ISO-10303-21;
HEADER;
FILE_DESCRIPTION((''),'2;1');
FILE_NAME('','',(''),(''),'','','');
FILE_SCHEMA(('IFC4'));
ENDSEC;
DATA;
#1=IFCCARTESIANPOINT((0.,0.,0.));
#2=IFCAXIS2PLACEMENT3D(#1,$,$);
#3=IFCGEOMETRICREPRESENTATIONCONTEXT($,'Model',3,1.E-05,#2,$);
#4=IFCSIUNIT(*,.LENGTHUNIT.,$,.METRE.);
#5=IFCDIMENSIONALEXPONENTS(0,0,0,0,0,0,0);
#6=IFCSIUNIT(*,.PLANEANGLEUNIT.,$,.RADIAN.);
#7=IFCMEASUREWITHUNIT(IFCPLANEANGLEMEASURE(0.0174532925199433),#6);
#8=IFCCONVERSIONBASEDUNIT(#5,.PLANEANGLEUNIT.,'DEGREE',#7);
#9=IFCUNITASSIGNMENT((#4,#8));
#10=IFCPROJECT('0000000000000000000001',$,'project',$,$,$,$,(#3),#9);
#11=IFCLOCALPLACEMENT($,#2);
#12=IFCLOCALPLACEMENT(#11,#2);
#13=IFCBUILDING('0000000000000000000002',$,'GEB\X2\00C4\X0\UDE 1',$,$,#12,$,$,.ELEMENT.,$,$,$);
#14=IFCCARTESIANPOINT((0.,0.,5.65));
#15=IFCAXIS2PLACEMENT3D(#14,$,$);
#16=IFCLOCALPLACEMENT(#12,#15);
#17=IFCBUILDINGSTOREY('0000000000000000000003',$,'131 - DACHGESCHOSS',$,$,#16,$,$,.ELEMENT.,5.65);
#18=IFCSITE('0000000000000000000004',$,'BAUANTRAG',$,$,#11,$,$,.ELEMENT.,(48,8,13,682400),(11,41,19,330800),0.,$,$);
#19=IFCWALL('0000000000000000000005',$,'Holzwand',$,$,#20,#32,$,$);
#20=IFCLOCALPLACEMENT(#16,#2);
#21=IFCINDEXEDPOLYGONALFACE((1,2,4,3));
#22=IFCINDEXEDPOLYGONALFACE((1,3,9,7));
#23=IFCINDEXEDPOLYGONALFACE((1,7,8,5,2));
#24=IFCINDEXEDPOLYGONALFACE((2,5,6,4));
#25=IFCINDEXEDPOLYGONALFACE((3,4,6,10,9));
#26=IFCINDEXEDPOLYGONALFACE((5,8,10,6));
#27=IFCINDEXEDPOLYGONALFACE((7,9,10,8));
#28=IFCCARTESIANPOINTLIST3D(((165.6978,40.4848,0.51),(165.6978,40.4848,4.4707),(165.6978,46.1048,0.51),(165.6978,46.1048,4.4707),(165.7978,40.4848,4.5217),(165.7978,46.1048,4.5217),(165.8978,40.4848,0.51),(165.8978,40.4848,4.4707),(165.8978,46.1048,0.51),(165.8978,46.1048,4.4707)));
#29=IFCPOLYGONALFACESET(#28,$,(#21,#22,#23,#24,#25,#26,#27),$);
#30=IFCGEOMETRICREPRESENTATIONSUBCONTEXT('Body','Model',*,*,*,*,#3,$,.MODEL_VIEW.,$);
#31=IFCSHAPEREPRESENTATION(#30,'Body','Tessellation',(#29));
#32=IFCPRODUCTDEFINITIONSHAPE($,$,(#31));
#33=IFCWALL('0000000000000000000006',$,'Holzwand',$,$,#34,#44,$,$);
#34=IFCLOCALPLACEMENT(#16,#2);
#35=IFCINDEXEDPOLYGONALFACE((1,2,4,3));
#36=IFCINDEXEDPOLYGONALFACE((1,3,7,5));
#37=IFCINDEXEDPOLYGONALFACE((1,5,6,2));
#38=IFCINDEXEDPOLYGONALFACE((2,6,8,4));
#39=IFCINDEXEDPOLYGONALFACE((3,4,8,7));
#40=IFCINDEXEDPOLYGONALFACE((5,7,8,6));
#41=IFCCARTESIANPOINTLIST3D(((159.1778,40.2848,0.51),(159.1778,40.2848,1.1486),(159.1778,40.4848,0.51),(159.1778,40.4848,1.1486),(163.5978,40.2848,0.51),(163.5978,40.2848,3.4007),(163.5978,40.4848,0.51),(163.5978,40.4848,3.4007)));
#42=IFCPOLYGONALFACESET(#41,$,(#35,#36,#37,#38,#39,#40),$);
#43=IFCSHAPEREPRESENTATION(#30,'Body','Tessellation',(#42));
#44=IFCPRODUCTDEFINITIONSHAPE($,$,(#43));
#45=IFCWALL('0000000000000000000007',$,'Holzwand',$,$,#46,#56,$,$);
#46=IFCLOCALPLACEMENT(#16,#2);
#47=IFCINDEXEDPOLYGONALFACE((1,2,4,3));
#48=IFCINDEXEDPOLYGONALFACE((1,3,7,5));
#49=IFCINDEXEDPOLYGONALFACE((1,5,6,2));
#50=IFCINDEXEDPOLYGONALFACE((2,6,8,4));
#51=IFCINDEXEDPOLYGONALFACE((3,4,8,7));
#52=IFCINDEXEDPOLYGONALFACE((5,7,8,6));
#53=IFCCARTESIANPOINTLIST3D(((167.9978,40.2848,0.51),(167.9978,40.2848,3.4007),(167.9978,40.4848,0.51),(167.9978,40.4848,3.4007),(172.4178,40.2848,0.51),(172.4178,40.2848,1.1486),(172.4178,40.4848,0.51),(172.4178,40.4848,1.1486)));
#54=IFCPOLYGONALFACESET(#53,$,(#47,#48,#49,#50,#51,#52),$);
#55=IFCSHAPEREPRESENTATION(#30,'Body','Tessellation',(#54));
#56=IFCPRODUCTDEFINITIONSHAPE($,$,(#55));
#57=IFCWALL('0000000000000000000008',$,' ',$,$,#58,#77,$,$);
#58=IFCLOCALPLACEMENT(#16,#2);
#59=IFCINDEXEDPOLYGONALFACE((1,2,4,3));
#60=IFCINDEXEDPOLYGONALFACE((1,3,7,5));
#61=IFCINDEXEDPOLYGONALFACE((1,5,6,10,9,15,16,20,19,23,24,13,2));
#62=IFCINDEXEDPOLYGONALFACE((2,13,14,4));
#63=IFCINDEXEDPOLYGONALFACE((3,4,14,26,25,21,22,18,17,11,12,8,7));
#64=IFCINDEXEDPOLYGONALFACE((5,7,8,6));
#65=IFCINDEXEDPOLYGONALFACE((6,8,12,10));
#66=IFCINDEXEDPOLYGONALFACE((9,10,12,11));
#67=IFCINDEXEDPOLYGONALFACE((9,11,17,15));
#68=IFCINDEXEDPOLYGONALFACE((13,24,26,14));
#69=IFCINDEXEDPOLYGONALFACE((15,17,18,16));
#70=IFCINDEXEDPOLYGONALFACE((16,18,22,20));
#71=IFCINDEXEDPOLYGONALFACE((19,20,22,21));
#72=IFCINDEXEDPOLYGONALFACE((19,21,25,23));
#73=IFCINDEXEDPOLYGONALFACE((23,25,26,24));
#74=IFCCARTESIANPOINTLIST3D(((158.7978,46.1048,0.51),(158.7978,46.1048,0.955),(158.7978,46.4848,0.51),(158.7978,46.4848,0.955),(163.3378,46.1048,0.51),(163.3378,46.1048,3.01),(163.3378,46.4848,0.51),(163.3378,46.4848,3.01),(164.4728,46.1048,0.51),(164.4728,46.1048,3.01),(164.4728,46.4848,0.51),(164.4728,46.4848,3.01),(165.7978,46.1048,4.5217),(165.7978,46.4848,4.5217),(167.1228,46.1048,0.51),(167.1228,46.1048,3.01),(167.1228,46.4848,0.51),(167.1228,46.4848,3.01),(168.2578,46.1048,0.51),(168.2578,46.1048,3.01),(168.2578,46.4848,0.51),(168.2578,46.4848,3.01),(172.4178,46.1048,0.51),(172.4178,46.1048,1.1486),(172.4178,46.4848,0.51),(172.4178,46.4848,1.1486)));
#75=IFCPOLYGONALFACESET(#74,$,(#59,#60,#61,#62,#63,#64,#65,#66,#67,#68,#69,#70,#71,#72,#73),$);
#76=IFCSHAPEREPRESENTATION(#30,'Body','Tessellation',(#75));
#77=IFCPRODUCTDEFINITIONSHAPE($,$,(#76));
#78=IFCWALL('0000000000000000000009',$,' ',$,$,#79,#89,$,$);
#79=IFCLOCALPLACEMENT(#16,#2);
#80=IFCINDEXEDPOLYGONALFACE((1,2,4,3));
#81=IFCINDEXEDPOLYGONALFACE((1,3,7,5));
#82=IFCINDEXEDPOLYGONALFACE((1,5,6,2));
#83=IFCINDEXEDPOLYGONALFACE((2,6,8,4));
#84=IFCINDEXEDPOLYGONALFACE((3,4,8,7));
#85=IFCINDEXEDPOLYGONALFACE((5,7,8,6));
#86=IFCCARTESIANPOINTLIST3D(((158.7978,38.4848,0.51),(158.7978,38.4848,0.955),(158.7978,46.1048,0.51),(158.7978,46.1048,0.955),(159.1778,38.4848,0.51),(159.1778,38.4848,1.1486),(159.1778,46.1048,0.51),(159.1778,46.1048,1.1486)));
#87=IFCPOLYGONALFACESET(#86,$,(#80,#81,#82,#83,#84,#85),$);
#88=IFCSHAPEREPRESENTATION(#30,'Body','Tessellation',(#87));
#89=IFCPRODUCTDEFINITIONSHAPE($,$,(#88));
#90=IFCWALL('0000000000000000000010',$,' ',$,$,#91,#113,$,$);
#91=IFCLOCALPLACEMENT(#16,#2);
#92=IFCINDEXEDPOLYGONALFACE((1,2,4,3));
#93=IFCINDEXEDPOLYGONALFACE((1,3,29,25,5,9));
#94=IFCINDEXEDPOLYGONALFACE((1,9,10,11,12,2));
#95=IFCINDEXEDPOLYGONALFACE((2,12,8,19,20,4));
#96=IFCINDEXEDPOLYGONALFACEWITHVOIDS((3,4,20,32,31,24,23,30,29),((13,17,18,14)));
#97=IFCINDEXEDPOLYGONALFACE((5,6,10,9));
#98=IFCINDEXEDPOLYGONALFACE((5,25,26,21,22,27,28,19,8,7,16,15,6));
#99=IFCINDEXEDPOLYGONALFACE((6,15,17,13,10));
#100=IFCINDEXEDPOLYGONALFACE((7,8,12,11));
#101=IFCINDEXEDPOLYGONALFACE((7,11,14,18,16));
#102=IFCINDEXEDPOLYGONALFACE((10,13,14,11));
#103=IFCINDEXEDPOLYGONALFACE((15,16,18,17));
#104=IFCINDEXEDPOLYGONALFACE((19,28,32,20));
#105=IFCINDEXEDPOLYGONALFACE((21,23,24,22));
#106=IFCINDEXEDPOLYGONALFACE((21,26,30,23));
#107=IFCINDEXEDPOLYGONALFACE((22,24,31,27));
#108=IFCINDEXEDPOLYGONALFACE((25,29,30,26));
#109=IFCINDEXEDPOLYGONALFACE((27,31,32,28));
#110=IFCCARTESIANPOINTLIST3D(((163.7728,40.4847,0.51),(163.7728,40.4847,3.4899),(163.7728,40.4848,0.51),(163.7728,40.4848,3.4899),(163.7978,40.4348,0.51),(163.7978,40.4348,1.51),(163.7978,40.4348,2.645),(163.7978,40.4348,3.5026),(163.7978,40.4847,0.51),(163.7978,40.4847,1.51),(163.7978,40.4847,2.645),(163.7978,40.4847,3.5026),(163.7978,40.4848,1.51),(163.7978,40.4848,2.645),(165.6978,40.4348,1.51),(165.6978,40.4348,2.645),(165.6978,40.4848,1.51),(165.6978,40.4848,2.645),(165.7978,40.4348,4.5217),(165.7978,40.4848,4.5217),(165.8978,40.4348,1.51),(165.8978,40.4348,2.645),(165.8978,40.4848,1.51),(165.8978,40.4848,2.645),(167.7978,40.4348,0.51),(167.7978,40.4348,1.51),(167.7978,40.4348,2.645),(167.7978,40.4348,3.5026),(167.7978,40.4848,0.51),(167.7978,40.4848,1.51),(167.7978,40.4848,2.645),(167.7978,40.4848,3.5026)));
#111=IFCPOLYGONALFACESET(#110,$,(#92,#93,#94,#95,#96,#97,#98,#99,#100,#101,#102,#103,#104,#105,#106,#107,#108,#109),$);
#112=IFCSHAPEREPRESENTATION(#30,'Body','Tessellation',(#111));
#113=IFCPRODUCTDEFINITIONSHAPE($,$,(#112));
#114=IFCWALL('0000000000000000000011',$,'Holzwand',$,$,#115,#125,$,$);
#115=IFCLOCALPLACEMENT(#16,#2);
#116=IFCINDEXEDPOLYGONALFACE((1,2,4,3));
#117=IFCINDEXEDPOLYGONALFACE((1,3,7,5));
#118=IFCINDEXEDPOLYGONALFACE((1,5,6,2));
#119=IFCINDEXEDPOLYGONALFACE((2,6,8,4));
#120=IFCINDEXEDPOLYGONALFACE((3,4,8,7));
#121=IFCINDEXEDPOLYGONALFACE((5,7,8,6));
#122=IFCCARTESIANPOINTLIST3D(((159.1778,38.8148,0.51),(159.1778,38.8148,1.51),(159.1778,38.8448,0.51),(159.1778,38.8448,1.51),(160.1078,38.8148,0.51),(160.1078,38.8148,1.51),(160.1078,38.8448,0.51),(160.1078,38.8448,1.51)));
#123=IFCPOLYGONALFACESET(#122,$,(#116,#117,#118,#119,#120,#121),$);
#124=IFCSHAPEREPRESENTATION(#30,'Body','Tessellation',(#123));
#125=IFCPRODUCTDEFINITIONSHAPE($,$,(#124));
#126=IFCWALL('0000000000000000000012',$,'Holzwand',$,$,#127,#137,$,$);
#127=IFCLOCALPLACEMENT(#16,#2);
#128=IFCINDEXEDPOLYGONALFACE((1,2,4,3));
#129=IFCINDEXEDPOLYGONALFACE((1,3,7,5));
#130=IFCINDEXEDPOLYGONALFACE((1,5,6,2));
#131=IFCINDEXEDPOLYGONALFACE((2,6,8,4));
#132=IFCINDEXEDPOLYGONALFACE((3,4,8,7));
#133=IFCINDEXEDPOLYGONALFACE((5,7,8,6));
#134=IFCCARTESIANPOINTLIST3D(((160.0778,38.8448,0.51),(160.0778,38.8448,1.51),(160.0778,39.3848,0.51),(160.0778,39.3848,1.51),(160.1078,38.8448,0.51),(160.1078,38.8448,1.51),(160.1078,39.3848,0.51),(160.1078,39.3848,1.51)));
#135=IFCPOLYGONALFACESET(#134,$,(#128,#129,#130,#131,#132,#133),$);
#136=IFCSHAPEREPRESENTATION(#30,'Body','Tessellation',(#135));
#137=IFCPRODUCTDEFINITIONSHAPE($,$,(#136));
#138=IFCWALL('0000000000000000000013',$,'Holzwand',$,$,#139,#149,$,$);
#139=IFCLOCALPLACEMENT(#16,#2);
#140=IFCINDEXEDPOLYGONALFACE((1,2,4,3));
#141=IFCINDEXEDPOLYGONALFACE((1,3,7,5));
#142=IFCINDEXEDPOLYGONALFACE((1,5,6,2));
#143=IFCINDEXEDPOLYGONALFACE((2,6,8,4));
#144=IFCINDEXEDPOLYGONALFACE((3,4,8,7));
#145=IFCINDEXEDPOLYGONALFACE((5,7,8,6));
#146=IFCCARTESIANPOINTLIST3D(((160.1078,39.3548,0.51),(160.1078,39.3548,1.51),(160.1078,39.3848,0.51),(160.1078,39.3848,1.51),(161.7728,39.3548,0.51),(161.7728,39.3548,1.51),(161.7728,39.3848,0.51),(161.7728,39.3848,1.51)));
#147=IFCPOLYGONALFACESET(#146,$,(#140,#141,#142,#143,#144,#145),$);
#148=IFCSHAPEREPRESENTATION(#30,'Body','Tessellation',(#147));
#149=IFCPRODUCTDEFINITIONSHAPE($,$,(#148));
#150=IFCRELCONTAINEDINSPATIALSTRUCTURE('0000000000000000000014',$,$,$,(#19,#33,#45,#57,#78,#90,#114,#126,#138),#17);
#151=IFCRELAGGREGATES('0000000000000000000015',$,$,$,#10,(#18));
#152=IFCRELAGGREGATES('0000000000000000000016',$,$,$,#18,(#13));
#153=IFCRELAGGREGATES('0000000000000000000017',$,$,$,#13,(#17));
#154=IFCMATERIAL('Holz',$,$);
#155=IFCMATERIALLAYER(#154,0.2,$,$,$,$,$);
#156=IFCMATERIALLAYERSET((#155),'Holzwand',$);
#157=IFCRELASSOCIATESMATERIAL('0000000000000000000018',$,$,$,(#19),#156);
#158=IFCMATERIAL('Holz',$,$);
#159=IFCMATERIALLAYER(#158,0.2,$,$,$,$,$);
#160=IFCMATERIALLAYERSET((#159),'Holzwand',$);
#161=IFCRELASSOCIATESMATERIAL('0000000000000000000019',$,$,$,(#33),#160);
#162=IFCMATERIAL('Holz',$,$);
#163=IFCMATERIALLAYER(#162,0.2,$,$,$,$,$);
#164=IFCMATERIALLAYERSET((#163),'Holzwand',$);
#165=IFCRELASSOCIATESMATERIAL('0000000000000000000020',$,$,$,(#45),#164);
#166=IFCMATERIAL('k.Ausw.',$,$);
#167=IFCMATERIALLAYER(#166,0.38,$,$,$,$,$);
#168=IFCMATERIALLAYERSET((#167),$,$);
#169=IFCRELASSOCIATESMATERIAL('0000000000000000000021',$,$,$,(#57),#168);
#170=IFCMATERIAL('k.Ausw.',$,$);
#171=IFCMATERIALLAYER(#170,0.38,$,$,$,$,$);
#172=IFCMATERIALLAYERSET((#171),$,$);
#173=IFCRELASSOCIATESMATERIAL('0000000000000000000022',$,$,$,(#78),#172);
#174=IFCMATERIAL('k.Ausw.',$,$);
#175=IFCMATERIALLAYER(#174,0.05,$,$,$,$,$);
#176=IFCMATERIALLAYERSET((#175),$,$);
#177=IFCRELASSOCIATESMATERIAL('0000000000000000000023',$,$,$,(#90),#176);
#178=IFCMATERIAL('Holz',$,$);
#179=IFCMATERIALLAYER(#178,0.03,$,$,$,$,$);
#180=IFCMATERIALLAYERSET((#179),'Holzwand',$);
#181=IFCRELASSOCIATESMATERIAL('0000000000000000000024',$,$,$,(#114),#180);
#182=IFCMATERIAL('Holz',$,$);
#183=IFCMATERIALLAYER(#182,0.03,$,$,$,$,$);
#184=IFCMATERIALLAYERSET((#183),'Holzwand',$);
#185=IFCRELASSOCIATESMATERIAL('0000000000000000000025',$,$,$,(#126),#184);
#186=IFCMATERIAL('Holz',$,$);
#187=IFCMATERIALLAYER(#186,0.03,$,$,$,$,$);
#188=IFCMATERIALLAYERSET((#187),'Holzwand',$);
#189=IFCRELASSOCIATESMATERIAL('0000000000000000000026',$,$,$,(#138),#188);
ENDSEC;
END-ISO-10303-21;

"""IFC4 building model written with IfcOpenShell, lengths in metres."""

from ifc_helpers import new_model, entity, si_unit, converted_unit, frame, frame_2d, origin, origin_with_axes, place, context, subcontext, project, spatial, polyline, rectangle, outline, extrude, clip, halfspace, bounded_halfspace, material, layer, layer_set, layer_usage, element, save


model = new_model("IFC4")

# Units and contexts
model_context = context("Model", 3, precision=1e-05, world=origin())
body_context = subcontext(model_context, "Body", "Model", "MODEL_VIEW")
ifc_project = project(units=[si_unit("LENGTHUNIT", "METRE"), converted_unit("PLANEANGLEUNIT", "DEGREE", entity("IfcPlaneAngleMeasure", 0.0174532925199433), si_unit("PLANEANGLEUNIT", "RADIAN"), dimensions=[0, 0, 0, 0, 0, 0, 0])], contexts=[model_context])

# Site, building, storey
site_placement = place(None, origin())
site = spatial("IfcSite", under=ifc_project, at=site_placement, Name="BAUANTRAG", CompositionType="ELEMENT", RefLatitude=(48, 8, 13, 682400), RefLongitude=(11, 41, 19, 330800), RefElevation=0.0)
building_placement = place(site_placement, origin())
building = spatial("IfcBuilding", under=site, at=building_placement, Name="GEBÄUDE 1", CompositionType="ELEMENT")
storey_placement = place(building_placement, frame((0.0, 0.0, 5.65)))
storey = spatial("IfcBuildingStorey", under=building, at=storey_placement, Name="131 - DACHGESCHOSS", CompositionType="ELEMENT", Elevation=5.65)

# Walls
ifc_material_1 = material(Name="Holz")
ifc_layer_1 = layer(ifc_material_1, 0.2)
ifc_layer_set_1 = layer_set([ifc_layer_1], Name="Holzwand")
ifc_layer_usage_1 = layer_usage(ifc_layer_set_1, "AXIS2", "POSITIVE", 0.0)
wall_1_placement = place(storey_placement, frame((165.6978, 46.1048, 0.51), z_axis=(0.0, 0.0, 1.0), x_axis=(0.0, -1.0, 0.0)))
element("IfcWall", 1, at=wall_1_placement, inside=storey, material=ifc_layer_usage_1, Name="Holzwand", context=body_context, shape_type="Clipping", body=[
    clip(clip(extrude(rectangle(XDim=5.62, YDim=0.2, at=frame_2d((2.81, 0.1), x_axis=(1.0, 0.0))), origin_with_axes(), (0.0, 0.0, 1.0), 4.0117), bounded_halfspace(frame((2.81, 0.05, 3.9862), z_axis=(0.0, 0.45399, -0.891007), x_axis=(0.0, 0.891007, 0.45399)), True, origin_with_axes(), polyline([(5.62, 0.0), (5.62, 0.1), (0.0, 0.1), (0.0, 0.0), (5.62, 0.0)]))), bounded_halfspace(frame((2.81, 0.15, 3.9862), z_axis=(0.0, -0.45399, -0.891007), x_axis=(0.0, -0.891007, 0.45399)), True, origin_with_axes(), polyline([(0.0, 0.2), (0.0, 0.1), (5.62, 0.1), (5.62, 0.2), (0.0, 0.2)]))),
])
ifc_material_2 = material(Name="Holz")
ifc_layer_2 = layer(ifc_material_2, 0.2)
ifc_layer_set_2 = layer_set([ifc_layer_2], Name="Holzwand")
ifc_layer_usage_2 = layer_usage(ifc_layer_set_2, "AXIS2", "POSITIVE", 0.0)
wall_2_placement = place(storey_placement, frame((163.5978, 40.4848, 0.51), z_axis=(0.0, 0.0, 1.0), x_axis=(-1.0, 0.0, 0.0)))
element("IfcWall", 2, at=wall_2_placement, inside=storey, material=ifc_layer_usage_2, Name="Holzwand", context=body_context, shape_type="Clipping", body=[
    clip(extrude(rectangle(XDim=4.42, YDim=0.2, at=frame_2d((2.21, 0.1), x_axis=(1.0, 0.0))), origin_with_axes(), (0.0, 0.0, 1.0), 2.8907), halfspace(frame((2.21, 0.1, 1.7647), z_axis=(-0.45399, 0.0, -0.891007), x_axis=(0.891007, 0.0, -0.45399)), True)),
])
ifc_material_3 = material(Name="Holz")
ifc_layer_3 = layer(ifc_material_3, 0.2)
ifc_layer_set_3 = layer_set([ifc_layer_3], Name="Holzwand")
ifc_layer_usage_3 = layer_usage(ifc_layer_set_3, "AXIS2", "POSITIVE", 0.0)
wall_3_placement = place(storey_placement, frame((172.4178, 40.4848, 0.51), z_axis=(0.0, 0.0, 1.0), x_axis=(-1.0, 0.0, 0.0)))
element("IfcWall", 3, at=wall_3_placement, inside=storey, material=ifc_layer_usage_3, Name="Holzwand", context=body_context, shape_type="Clipping", body=[
    clip(extrude(rectangle(XDim=4.42, YDim=0.2, at=frame_2d((2.21, 0.1), x_axis=(1.0, 0.0))), origin_with_axes(), (0.0, 0.0, 1.0), 2.8907), halfspace(frame((2.21, 0.1, 1.7647), z_axis=(0.45399, 0.0, -0.891007), x_axis=(0.891007, 0.0, 0.45399)), True)),
])

# Wall, openings
ifc_material_4 = material(Name="k.Ausw.")
ifc_layer_4 = layer(ifc_material_4, 0.38)
ifc_layer_set_4 = layer_set([ifc_layer_4])
ifc_layer_usage_4 = layer_usage(ifc_layer_set_4, "AXIS2", "POSITIVE", 0.0)
wall_4_placement = place(storey_placement, frame((172.4178, 46.4848, 0.51), z_axis=(0.0, 0.0, 1.0), x_axis=(-1.0, 0.0, 0.0)))
wall_4 = element("IfcWall", 4, at=wall_4_placement, inside=storey, material=ifc_layer_usage_4, Name=" ", context=body_context, shape_type="Clipping", body=[
    clip(clip(extrude(rectangle(XDim=13.62, YDim=0.38, at=frame_2d((6.81, 0.19), x_axis=(1.0, 0.0))), origin_with_axes(), (0.0, 0.0, 1.0), 4.0117), bounded_halfspace(frame((10.12, 0.19, 2.2283), z_axis=(-0.45399, 0.0, -0.891007), x_axis=(0.0, -1.0, 0.0)), True, origin_with_axes(), polyline([(6.62, 0.38), (6.62, 0.0), (13.62, 0.0), (13.62, 0.38), (6.62, 0.38)]))), bounded_halfspace(frame((3.31, 0.19, 2.3251), z_axis=(0.45399, 0.0, -0.891007), x_axis=(0.0, -1.0, 0.0)), True, origin_with_axes(), polyline([(0.0, 0.38), (0.0, 0.0), (6.62, 0.0), (6.62, 0.38), (0.0, 0.38)]))),
])
opening_1_placement = place(wall_4_placement, frame((5.295, 0.38, 0.0), z_axis=(0.0, -1.0, 0.0), x_axis=(0.0, 0.0, 1.0)))
element("IfcOpeningElement", 5, at=opening_1_placement, cuts=wall_4, ObjectType="Opening", context=body_context, shape_type="SweptSolid", body=[
    extrude(outline(polyline([(0.0, 1.135), (2.5, 1.135), (2.5, 0.0), (0.0, 0.0), (0.0, 1.135)])), origin_with_axes(), (0.0, 0.0, 1.0), 0.38),
])
opening_2_placement = place(wall_4_placement, frame((9.08, 0.38, 0.0), z_axis=(0.0, -1.0, 0.0), x_axis=(0.0, 0.0, 1.0)))
element("IfcOpeningElement", 6, at=opening_2_placement, cuts=wall_4, ObjectType="Opening", context=body_context, shape_type="SweptSolid", body=[
    extrude(outline(polyline([(0.0, 1.135), (2.5, 1.135), (2.5, 0.0), (0.0, 0.0), (0.0, 1.135)])), origin_with_axes(), (0.0, 0.0, 1.0), 0.38),
])

# Wall
ifc_material_5 = material(Name="k.Ausw.")
ifc_layer_5 = layer(ifc_material_5, 0.38)
ifc_layer_set_5 = layer_set([ifc_layer_5])
ifc_layer_usage_5 = layer_usage(ifc_layer_set_5, "AXIS2", "POSITIVE", 0.0)
wall_5_placement = place(storey_placement, frame((158.7978, 46.1048, 0.51), z_axis=(0.0, 0.0, 1.0), x_axis=(0.0, -1.0, 0.0)))
element("IfcWall", 7, at=wall_5_placement, inside=storey, material=ifc_layer_usage_5, Name=" ", context=body_context, shape_type="Clipping", body=[
    clip(extrude(rectangle(XDim=7.62, YDim=0.38, at=frame_2d((3.81, 0.19), x_axis=(1.0, 0.0))), origin_with_axes(), (0.0, 0.0, 1.0), 0.6386), halfspace(frame((3.81, 0.19, 0.5418), z_axis=(0.0, 0.45399, -0.891007), x_axis=(0.0, -0.891007, -0.45399)), True)),
])

# Wall, openings
ifc_material_6 = material(Name="k.Ausw.")
ifc_layer_6 = layer(ifc_material_6, 0.05)
ifc_layer_set_6 = layer_set([ifc_layer_6])
ifc_layer_usage_6 = layer_usage(ifc_layer_set_6, "AXIS2", "POSITIVE", 0.0)
wall_6_placement = place(storey_placement, frame((167.7978, 40.4848, 0.51), z_axis=(0.0, 0.0, 1.0), x_axis=(-1.0, 0.0, 0.0)))
wall_6 = element("IfcWall", 8, at=wall_6_placement, inside=storey, material=ifc_layer_usage_6, Name=" ", context=body_context, shape_type="Clipping", body=[
    clip(clip(extrude(outline(polyline([(-4.025, -0.05), (0.0, -0.05), (0.0, -0.0499), (-0.025, -0.0499), (-0.025, 0.0), (-4.025, 0.0), (-4.025, -0.05)])), frame((4.025, 0.05, 0.0), z_axis=(0.0, 0.0, 1.0), x_axis=(1.0, 0.0, 0.0)), (0.0, 0.0, 1.0), 4.0117), bounded_halfspace(frame((3.3417, 0.0167, 3.3281), z_axis=(-0.45399, 0.0, -0.891007), x_axis=(-0.891007, 0.0, 0.45399)), True, origin_with_axes(), polyline([(4.0, 0.05), (2.0, 0.05), (2.0, 0.0), (4.025, 0.0), (4.025, 0.0001), (4.0, 0.0001), (4.0, 0.05)]))), bounded_halfspace(frame((1.0, 0.025, 3.5022), z_axis=(0.45399, 0.0, -0.891007), x_axis=(0.891007, 0.0, 0.45399)), True, origin_with_axes(), polyline([(0.0, 0.0), (2.0, 0.0), (2.0, 0.05), (0.0, 0.05), (0.0, 0.0)]))),
])
opening_3_placement = place(wall_6_placement, frame((2.1, 0.0, 1.0), z_axis=(0.0, 1.0, 0.0), x_axis=(0.0, 0.0, 1.0)))
element("IfcOpeningElement", 9, at=opening_3_placement, cuts=wall_6, ObjectType="Opening", context=body_context, shape_type="SweptSolid", body=[
    extrude(outline(polyline([(0.0, 1.9), (1.135, 1.9), (1.135, 0.0), (0.0, 0.0), (0.0, 1.9)])), origin_with_axes(), (0.0, 0.0, 1.0), 0.05),
])
opening_4_placement = place(wall_6_placement, frame((0.0, 0.0, 1.0), z_axis=(0.0, 1.0, 0.0), x_axis=(0.0, 0.0, 1.0)))
element("IfcOpeningElement", 10, at=opening_4_placement, cuts=wall_6, ObjectType="Opening", context=body_context, shape_type="SweptSolid", body=[
    extrude(outline(polyline([(0.0, 1.9), (1.135, 1.9), (1.135, 0.0), (0.0, 0.0), (0.0, 1.9)])), origin_with_axes(), (0.0, 0.0, 1.0), 0.05),
])

# Walls
ifc_material_7 = material(Name="Holz")
ifc_layer_7 = layer(ifc_material_7, 0.03)
ifc_layer_set_7 = layer_set([ifc_layer_7], Name="Holzwand")
ifc_layer_usage_7 = layer_usage(ifc_layer_set_7, "AXIS2", "POSITIVE", 0.0)
wall_7_placement = place(storey_placement, frame((160.1078, 38.8448, 0.51), z_axis=(0.0, 0.0, 1.0), x_axis=(-1.0, 0.0, 0.0)))
element("IfcWall", 11, at=wall_7_placement, inside=storey, material=ifc_layer_usage_7, Name="Holzwand", context=body_context, shape_type="SweptSolid", body=[
    extrude(rectangle(XDim=0.93, YDim=0.03, at=frame_2d((0.465, 0.015), x_axis=(1.0, 0.0))), origin_with_axes(), (0.0, 0.0, 1.0), 1.0),
])
ifc_material_8 = material(Name="Holz")
ifc_layer_8 = layer(ifc_material_8, 0.03)
ifc_layer_set_8 = layer_set([ifc_layer_8], Name="Holzwand")
ifc_layer_usage_8 = layer_usage(ifc_layer_set_8, "AXIS2", "POSITIVE", 0.0)
wall_8_placement = place(storey_placement, frame((160.0778, 39.3848, 0.51), z_axis=(0.0, 0.0, 1.0), x_axis=(0.0, -1.0, 0.0)))
element("IfcWall", 12, at=wall_8_placement, inside=storey, material=ifc_layer_usage_8, Name="Holzwand", context=body_context, shape_type="SweptSolid", body=[
    extrude(rectangle(XDim=0.54, YDim=0.03, at=frame_2d((0.27, 0.015), x_axis=(1.0, 0.0))), origin_with_axes(), (0.0, 0.0, 1.0), 1.0),
])
ifc_material_9 = material(Name="Holz")
ifc_layer_9 = layer(ifc_material_9, 0.03)
ifc_layer_set_9 = layer_set([ifc_layer_9], Name="Holzwand")
ifc_layer_usage_9 = layer_usage(ifc_layer_set_9, "AXIS2", "POSITIVE", 0.0)
wall_9_placement = place(storey_placement, frame((161.7728, 39.3848, 0.51), z_axis=(0.0, 0.0, 1.0), x_axis=(-1.0, 0.0, 0.0)))
element("IfcWall", 13, at=wall_9_placement, inside=storey, material=ifc_layer_usage_9, Name="Holzwand", context=body_context, shape_type="SweptSolid", body=[
    extrude(rectangle(XDim=1.665, YDim=0.03, at=frame_2d((0.8325, 0.015), x_axis=(1.0, 0.0))), origin_with_axes(), (0.0, 0.0, 1.0), 1.0),
])

save(model, "model.ifc")
